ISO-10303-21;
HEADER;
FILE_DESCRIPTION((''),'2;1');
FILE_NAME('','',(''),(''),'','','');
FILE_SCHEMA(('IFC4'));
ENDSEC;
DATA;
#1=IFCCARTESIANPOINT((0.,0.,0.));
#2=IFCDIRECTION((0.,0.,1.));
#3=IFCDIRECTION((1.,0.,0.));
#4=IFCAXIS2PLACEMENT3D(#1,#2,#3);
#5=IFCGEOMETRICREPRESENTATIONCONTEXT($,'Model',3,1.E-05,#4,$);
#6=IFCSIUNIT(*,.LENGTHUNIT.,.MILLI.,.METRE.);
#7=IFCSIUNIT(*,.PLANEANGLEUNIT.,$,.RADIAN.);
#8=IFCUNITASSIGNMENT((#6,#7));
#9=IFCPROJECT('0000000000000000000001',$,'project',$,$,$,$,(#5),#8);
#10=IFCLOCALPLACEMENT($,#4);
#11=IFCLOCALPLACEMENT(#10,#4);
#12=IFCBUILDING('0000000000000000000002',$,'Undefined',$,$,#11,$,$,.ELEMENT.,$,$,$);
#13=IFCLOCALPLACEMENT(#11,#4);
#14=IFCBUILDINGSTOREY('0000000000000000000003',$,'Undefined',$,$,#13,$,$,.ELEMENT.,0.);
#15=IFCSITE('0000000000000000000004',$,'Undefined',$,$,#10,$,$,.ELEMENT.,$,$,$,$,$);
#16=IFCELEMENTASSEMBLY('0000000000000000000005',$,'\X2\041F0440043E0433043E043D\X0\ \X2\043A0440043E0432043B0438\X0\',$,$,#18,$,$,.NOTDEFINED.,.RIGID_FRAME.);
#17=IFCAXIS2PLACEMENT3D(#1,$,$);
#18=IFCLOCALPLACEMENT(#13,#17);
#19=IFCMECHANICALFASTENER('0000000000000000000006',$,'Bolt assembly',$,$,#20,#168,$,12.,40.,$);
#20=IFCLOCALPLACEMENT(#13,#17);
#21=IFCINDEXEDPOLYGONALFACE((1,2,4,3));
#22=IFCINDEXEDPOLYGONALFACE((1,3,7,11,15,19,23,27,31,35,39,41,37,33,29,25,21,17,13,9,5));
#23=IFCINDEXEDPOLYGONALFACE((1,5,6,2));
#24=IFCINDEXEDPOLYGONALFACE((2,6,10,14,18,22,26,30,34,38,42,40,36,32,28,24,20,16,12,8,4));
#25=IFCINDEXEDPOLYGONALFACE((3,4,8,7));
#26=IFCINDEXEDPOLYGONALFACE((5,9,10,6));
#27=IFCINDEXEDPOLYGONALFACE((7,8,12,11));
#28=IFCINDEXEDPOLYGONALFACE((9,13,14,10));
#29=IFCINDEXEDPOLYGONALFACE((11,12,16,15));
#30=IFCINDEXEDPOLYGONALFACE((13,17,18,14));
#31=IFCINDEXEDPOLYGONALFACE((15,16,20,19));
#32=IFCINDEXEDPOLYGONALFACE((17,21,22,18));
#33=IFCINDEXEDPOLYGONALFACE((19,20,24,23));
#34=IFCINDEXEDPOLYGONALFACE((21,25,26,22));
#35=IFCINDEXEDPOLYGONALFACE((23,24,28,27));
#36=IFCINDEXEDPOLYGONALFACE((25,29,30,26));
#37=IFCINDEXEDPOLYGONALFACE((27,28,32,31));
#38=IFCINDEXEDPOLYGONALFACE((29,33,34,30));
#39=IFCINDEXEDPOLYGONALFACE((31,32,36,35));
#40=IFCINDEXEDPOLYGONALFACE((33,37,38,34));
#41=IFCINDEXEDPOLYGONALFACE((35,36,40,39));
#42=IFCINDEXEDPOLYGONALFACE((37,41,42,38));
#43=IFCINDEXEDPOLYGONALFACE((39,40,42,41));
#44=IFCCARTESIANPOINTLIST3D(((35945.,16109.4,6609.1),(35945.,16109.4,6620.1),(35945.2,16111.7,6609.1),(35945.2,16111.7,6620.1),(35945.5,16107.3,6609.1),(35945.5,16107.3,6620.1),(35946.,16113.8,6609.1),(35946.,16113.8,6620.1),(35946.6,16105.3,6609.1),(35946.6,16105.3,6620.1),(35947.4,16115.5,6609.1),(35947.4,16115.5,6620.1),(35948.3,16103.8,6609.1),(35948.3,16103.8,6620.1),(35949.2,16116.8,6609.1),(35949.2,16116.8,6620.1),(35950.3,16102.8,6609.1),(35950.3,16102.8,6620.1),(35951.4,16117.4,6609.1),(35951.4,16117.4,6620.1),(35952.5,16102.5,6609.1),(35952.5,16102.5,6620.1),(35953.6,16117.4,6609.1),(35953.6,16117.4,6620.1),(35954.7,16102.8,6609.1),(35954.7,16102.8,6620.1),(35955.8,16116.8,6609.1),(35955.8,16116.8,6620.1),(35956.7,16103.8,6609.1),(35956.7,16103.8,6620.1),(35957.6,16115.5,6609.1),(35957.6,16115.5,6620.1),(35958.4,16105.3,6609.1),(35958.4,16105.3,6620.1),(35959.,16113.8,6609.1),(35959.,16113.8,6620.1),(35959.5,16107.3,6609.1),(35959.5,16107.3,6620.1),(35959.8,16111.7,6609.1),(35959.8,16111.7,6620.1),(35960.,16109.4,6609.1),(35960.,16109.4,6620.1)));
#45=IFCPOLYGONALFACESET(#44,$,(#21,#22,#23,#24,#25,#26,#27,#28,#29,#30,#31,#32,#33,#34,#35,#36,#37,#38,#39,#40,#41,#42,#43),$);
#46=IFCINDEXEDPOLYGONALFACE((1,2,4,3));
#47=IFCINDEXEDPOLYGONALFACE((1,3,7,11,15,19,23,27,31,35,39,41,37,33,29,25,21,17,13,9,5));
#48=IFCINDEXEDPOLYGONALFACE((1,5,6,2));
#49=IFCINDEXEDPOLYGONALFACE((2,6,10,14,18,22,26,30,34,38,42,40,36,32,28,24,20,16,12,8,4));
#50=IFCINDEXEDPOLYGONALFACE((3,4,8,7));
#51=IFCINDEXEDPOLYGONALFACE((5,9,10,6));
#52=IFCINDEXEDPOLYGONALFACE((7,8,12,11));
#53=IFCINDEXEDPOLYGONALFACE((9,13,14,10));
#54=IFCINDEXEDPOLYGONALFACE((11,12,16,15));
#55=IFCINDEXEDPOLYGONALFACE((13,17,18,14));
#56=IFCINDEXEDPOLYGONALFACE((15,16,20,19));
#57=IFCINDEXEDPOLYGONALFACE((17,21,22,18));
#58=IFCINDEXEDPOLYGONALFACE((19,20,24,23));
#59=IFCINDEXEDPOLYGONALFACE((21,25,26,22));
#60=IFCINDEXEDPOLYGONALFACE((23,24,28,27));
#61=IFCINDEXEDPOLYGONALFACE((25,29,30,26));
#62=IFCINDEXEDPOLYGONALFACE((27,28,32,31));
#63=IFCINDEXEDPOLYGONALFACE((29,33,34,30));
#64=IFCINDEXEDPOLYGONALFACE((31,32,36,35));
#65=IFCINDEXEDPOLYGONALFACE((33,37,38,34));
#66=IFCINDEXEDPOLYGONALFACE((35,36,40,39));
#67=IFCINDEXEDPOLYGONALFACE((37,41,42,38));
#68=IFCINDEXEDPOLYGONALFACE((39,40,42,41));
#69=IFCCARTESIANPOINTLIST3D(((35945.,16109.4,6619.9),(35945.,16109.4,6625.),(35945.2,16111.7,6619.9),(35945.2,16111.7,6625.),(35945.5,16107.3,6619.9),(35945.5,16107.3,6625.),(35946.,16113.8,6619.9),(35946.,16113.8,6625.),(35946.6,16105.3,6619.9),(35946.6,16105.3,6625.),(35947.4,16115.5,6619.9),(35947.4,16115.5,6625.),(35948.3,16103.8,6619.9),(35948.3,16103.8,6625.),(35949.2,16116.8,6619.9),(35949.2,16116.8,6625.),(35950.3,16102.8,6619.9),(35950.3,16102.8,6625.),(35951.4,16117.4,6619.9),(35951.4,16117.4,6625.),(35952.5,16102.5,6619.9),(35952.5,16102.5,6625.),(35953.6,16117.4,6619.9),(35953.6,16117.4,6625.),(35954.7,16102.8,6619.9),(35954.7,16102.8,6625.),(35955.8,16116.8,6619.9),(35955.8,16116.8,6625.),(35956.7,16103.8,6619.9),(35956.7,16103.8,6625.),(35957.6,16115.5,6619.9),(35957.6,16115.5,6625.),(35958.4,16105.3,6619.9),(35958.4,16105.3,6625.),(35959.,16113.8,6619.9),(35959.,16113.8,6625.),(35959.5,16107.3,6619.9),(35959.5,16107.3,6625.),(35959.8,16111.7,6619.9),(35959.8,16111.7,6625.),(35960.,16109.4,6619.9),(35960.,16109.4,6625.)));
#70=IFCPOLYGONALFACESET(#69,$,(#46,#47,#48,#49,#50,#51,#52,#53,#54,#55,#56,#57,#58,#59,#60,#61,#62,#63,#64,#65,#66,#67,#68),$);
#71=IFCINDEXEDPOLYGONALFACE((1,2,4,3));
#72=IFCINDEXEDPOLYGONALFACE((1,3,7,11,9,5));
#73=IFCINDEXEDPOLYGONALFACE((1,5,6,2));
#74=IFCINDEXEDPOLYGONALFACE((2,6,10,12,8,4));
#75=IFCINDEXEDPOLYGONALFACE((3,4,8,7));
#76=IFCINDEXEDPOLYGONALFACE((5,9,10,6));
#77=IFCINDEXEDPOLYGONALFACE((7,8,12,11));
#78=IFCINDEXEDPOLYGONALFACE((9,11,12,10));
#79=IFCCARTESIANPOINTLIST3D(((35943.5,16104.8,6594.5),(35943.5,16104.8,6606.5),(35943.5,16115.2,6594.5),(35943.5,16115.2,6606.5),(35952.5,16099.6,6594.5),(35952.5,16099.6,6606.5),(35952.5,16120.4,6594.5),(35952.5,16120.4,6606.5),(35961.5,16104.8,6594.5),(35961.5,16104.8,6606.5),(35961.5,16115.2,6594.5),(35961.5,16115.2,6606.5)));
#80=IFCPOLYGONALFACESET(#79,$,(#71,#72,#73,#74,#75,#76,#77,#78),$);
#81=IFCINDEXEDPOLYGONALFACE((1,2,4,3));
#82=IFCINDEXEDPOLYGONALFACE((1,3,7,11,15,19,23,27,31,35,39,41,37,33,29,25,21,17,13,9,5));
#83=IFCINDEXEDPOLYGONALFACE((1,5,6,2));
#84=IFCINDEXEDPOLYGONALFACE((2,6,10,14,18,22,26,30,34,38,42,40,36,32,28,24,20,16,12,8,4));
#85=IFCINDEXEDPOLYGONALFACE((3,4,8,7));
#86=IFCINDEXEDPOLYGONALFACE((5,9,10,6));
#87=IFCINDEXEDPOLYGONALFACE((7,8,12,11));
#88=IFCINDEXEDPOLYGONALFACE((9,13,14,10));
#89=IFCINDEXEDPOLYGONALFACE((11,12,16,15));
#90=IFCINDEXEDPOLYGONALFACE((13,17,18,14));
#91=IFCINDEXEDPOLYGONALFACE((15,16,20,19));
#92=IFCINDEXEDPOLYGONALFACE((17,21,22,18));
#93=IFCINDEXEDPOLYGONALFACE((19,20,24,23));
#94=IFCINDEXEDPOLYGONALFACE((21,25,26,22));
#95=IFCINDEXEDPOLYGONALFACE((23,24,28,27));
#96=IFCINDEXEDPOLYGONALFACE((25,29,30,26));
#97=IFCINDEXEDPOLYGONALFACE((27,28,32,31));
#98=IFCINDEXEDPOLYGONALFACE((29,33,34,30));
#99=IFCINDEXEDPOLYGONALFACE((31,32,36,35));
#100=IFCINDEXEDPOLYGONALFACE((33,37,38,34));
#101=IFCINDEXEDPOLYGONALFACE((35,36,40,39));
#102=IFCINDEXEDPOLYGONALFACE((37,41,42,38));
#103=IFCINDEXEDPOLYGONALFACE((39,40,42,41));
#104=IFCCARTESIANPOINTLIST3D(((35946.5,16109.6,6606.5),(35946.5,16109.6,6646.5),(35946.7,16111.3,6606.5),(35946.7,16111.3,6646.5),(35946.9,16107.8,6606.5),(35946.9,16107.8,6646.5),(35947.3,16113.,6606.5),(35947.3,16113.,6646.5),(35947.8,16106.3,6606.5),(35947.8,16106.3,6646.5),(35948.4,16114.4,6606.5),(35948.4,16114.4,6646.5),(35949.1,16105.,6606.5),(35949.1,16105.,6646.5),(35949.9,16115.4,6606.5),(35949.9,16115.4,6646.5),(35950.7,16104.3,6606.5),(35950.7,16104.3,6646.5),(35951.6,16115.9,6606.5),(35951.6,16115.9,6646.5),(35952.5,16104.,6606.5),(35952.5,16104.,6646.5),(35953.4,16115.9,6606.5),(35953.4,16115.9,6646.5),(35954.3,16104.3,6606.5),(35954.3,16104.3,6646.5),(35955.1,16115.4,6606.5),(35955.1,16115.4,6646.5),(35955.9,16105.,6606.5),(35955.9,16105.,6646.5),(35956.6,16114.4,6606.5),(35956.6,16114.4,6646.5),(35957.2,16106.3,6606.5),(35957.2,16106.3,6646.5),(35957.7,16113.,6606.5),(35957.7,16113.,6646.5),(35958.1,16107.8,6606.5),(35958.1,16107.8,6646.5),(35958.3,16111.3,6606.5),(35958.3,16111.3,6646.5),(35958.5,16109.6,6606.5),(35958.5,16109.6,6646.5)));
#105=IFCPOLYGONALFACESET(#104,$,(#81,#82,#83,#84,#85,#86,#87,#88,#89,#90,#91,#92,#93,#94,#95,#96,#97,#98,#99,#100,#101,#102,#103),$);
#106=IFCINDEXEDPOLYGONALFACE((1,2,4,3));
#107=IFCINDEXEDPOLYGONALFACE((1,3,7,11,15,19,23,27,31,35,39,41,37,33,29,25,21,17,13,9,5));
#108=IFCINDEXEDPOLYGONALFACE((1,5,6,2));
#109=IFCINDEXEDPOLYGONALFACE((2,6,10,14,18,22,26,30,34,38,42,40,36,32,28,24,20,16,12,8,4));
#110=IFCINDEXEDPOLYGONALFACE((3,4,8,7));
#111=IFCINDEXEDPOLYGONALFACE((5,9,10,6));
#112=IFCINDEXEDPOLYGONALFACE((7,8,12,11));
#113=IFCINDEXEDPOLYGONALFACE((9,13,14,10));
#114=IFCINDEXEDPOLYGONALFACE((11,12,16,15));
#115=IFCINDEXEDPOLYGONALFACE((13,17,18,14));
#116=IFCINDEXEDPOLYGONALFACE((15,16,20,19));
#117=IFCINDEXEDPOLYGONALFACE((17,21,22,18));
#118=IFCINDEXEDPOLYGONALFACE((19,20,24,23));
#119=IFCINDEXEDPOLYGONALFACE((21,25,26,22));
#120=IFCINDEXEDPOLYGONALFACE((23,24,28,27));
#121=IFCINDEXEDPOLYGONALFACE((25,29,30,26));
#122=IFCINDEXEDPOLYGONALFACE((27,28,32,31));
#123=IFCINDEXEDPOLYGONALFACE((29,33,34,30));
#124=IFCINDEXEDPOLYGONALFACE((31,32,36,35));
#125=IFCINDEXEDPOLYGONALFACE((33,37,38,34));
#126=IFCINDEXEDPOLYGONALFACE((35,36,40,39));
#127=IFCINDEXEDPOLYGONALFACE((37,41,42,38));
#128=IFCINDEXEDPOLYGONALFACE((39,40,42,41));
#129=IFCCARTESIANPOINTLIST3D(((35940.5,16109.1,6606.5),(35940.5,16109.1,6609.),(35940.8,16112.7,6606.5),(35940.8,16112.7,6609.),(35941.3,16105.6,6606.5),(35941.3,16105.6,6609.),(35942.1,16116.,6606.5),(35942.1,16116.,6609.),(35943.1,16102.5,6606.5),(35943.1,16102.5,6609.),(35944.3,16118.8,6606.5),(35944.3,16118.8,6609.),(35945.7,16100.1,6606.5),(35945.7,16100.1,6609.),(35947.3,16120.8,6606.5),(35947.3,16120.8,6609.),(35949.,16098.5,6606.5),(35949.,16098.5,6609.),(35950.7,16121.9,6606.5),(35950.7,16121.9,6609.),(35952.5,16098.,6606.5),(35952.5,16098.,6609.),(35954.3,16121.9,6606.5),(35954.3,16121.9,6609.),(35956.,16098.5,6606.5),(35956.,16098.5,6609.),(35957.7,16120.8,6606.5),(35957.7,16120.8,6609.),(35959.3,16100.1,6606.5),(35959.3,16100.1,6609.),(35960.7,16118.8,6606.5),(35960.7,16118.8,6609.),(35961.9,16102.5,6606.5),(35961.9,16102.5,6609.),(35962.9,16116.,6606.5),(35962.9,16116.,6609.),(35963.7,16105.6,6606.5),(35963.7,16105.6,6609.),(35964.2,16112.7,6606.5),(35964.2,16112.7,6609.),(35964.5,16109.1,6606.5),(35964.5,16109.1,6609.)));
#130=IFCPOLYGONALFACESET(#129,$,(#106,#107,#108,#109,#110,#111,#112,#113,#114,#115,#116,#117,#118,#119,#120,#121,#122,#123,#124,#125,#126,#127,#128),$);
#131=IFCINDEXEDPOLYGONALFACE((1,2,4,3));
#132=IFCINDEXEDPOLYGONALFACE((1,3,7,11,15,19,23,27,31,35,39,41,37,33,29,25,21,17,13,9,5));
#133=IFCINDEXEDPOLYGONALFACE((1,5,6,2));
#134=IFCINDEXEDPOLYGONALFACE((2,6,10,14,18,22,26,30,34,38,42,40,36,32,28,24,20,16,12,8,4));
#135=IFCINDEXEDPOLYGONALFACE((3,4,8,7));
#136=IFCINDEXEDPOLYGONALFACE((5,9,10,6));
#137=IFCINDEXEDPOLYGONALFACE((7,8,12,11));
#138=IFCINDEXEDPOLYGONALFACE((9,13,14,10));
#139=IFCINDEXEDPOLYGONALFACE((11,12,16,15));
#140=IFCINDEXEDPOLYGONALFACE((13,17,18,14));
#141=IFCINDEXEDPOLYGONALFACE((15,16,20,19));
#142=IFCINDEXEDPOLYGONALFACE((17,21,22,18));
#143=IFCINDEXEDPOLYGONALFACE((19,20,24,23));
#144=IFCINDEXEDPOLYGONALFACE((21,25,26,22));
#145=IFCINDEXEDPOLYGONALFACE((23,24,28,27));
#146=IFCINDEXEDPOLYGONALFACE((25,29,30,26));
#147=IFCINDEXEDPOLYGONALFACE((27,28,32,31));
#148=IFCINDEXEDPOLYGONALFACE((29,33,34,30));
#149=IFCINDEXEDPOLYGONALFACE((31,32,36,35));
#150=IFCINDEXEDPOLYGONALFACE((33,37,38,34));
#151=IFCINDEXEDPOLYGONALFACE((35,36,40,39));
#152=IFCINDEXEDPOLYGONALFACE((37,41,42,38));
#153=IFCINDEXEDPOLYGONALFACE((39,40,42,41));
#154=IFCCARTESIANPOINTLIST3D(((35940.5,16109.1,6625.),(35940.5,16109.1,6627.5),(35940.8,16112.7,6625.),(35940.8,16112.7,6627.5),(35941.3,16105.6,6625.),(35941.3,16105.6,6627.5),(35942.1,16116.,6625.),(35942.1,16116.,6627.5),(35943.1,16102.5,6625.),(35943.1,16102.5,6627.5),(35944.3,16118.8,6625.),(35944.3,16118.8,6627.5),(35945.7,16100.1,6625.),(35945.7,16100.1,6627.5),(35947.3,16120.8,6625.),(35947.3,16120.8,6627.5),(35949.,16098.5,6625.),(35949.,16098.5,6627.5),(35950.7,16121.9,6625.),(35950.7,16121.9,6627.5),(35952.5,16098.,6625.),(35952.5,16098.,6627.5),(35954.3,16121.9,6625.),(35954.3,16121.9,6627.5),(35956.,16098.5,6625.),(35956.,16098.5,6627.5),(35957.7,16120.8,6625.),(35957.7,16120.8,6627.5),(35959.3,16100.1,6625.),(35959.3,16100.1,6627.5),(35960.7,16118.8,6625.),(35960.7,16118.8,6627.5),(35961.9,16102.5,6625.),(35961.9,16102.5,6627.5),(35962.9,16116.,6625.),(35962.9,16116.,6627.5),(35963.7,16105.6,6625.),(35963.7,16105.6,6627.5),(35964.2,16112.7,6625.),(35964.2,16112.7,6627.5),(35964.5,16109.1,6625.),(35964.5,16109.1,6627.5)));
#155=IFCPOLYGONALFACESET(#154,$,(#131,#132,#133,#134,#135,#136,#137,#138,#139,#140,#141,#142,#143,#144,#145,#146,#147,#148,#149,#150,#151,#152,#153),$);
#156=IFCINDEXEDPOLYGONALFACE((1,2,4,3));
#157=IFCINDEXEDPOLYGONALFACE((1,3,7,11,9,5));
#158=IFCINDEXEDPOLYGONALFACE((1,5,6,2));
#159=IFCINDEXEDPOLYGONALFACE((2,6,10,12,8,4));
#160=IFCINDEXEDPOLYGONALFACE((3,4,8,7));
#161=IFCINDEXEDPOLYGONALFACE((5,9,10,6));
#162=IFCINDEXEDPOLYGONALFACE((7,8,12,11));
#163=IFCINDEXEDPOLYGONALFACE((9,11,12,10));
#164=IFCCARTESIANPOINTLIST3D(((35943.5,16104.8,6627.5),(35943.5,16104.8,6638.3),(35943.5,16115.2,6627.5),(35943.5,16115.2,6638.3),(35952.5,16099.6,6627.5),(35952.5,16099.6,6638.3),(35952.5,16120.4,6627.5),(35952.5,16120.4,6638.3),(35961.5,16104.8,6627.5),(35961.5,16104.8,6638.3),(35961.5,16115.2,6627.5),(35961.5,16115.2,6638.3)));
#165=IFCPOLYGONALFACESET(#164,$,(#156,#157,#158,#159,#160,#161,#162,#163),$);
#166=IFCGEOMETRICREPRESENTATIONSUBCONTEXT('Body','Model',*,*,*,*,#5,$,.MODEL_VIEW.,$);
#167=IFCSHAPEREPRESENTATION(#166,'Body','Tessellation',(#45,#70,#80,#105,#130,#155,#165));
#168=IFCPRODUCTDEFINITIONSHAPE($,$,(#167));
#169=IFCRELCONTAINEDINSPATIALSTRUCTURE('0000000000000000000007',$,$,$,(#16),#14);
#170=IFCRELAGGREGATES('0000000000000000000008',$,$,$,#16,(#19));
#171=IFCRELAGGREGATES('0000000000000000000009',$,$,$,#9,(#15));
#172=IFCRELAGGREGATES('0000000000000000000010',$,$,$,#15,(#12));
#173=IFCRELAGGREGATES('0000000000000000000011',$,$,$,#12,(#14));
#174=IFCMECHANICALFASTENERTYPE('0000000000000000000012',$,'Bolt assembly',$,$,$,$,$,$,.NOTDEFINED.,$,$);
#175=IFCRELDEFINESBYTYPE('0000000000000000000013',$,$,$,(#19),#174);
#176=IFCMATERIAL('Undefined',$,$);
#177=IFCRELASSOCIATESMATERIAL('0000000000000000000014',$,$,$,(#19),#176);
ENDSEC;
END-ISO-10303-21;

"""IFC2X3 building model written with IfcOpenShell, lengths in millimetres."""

from ifc_helpers import new_model, si_unit, frame, origin_with_axes, origin_2d_with_axis, place, context, subcontext, project, spatial, polyline, circle, outline, extrude, source, transform, mapped, material, type_object, element, aggregate, save


model = new_model("IFC2X3")

# Units and contexts
model_context = context("Model", 3, precision=1e-05, world=origin_with_axes())
body_context = subcontext(model_context, "Body", "Model", "MODEL_VIEW")
ifc_project = project(units=[si_unit("LENGTHUNIT", "METRE", prefix="MILLI"), si_unit("PLANEANGLEUNIT", "RADIAN")], contexts=[model_context])

# Site, building, storey
site_placement = place(None, origin_with_axes())
site = spatial("IfcSite", under=ifc_project, at=site_placement, Name="Undefined", CompositionType="ELEMENT")
building_placement = place(site_placement, origin_with_axes())
building = spatial("IfcBuilding", under=site, at=building_placement, Name="Undefined", CompositionType="ELEMENT")
storey_placement = place(building_placement, origin_with_axes())
storey = spatial("IfcBuildingStorey", under=building, at=storey_placement, Name="Undefined", CompositionType="ELEMENT", Elevation=0.0)

# Element assembly
assembly_1_placement = place(storey_placement, origin_with_axes())
assembly_1 = element("IfcElementAssembly", 1, at=assembly_1_placement, inside=storey, Name="Прогон кровли", AssemblyPlace="NOTDEFINED", PredefinedType="RIGID_FRAME")

# Mechanical fastener
ifc_material_1 = material(Name="Undefined")
mechanical_fastener_type = type_object("IfcMechanicalFastenerType", Name="Bolt assembly")
shared_shape_1 = source(origin_with_axes(), body_context, "Body", "SweptSolid", [
    extrude(circle(Radius=7.5, at=origin_2d_with_axis()), frame((0.0, -10.9, 0.0), z_axis=(0.0, 1.0, 0.0), x_axis=(1.0, 0.0, 0.0)), (0.0, 0.0, 1.0), 11.0),
    extrude(circle(Radius=7.5, at=origin_2d_with_axis()), frame((0.0, -0.1, 0.0), z_axis=(0.0, 1.0, 0.0), x_axis=(1.0, 0.0, 0.0)), (0.0, 0.0, 1.0), 5.1),
    extrude(outline(polyline([(10.4, 0.0), (5.2, 9.0), (-5.2, 9.0), (-10.4, 0.0), (-5.2, -9.0), (5.2, -9.0), (10.4, 0.0)])), frame((0.0, -25.5, 0.0), z_axis=(0.0, 1.0, 0.0), x_axis=(1.0, 0.0, 0.0)), (0.0, 0.0, 1.0), 12.0),
    extrude(circle(Radius=6.0, at=origin_2d_with_axis()), frame((0.0, -13.5, 0.0), z_axis=(0.0, 1.0, 0.0), x_axis=(1.0, 0.0, 0.0)), (0.0, 0.0, 1.0), 40.0),
    extrude(circle(Radius=12.0, at=origin_2d_with_axis()), frame((0.0, -13.5, 0.0), z_axis=(0.0, 1.0, 0.0), x_axis=(1.0, 0.0, 0.0)), (0.0, 0.0, 1.0), 2.5),
    extrude(circle(Radius=12.0, at=origin_2d_with_axis()), frame((0.0, 5.0, 0.0), z_axis=(0.0, 1.0, 0.0), x_axis=(1.0, 0.0, 0.0)), (0.0, 0.0, 1.0), 2.5),
    extrude(outline(polyline([(10.4, 0.0), (5.2, 9.0), (-5.2, 9.0), (-10.4, 0.0), (-5.2, -9.0), (5.2, -9.0), (10.4, 0.0)])), frame((0.0, 7.5, 0.0), z_axis=(0.0, 1.0, 0.0), x_axis=(1.0, 0.0, 0.0)), (0.0, 0.0, 1.0), 10.8),
])
mechanical_fastener_1_placement = place(assembly_1_placement, frame((35952.5, 16110.0, 6620.0), z_axis=(-1.0, 0.0, 0.0), x_axis=(0.0, -1.0, 0.0)))
mechanical_fastener_1 = element("IfcMechanicalFastener", 2, at=mechanical_fastener_1_placement, type_object=mechanical_fastener_type, material=ifc_material_1, Name="Bolt assembly", NominalDiameter=12.0, NominalLength=40.0, context=body_context, shape_type="MappedRepresentation", body=[
    mapped(shared_shape_1, transform((0.0, 0.0, 0.0))),
])
aggregate(assembly_1, [mechanical_fastener_1])

save(model, "model.ifc")
